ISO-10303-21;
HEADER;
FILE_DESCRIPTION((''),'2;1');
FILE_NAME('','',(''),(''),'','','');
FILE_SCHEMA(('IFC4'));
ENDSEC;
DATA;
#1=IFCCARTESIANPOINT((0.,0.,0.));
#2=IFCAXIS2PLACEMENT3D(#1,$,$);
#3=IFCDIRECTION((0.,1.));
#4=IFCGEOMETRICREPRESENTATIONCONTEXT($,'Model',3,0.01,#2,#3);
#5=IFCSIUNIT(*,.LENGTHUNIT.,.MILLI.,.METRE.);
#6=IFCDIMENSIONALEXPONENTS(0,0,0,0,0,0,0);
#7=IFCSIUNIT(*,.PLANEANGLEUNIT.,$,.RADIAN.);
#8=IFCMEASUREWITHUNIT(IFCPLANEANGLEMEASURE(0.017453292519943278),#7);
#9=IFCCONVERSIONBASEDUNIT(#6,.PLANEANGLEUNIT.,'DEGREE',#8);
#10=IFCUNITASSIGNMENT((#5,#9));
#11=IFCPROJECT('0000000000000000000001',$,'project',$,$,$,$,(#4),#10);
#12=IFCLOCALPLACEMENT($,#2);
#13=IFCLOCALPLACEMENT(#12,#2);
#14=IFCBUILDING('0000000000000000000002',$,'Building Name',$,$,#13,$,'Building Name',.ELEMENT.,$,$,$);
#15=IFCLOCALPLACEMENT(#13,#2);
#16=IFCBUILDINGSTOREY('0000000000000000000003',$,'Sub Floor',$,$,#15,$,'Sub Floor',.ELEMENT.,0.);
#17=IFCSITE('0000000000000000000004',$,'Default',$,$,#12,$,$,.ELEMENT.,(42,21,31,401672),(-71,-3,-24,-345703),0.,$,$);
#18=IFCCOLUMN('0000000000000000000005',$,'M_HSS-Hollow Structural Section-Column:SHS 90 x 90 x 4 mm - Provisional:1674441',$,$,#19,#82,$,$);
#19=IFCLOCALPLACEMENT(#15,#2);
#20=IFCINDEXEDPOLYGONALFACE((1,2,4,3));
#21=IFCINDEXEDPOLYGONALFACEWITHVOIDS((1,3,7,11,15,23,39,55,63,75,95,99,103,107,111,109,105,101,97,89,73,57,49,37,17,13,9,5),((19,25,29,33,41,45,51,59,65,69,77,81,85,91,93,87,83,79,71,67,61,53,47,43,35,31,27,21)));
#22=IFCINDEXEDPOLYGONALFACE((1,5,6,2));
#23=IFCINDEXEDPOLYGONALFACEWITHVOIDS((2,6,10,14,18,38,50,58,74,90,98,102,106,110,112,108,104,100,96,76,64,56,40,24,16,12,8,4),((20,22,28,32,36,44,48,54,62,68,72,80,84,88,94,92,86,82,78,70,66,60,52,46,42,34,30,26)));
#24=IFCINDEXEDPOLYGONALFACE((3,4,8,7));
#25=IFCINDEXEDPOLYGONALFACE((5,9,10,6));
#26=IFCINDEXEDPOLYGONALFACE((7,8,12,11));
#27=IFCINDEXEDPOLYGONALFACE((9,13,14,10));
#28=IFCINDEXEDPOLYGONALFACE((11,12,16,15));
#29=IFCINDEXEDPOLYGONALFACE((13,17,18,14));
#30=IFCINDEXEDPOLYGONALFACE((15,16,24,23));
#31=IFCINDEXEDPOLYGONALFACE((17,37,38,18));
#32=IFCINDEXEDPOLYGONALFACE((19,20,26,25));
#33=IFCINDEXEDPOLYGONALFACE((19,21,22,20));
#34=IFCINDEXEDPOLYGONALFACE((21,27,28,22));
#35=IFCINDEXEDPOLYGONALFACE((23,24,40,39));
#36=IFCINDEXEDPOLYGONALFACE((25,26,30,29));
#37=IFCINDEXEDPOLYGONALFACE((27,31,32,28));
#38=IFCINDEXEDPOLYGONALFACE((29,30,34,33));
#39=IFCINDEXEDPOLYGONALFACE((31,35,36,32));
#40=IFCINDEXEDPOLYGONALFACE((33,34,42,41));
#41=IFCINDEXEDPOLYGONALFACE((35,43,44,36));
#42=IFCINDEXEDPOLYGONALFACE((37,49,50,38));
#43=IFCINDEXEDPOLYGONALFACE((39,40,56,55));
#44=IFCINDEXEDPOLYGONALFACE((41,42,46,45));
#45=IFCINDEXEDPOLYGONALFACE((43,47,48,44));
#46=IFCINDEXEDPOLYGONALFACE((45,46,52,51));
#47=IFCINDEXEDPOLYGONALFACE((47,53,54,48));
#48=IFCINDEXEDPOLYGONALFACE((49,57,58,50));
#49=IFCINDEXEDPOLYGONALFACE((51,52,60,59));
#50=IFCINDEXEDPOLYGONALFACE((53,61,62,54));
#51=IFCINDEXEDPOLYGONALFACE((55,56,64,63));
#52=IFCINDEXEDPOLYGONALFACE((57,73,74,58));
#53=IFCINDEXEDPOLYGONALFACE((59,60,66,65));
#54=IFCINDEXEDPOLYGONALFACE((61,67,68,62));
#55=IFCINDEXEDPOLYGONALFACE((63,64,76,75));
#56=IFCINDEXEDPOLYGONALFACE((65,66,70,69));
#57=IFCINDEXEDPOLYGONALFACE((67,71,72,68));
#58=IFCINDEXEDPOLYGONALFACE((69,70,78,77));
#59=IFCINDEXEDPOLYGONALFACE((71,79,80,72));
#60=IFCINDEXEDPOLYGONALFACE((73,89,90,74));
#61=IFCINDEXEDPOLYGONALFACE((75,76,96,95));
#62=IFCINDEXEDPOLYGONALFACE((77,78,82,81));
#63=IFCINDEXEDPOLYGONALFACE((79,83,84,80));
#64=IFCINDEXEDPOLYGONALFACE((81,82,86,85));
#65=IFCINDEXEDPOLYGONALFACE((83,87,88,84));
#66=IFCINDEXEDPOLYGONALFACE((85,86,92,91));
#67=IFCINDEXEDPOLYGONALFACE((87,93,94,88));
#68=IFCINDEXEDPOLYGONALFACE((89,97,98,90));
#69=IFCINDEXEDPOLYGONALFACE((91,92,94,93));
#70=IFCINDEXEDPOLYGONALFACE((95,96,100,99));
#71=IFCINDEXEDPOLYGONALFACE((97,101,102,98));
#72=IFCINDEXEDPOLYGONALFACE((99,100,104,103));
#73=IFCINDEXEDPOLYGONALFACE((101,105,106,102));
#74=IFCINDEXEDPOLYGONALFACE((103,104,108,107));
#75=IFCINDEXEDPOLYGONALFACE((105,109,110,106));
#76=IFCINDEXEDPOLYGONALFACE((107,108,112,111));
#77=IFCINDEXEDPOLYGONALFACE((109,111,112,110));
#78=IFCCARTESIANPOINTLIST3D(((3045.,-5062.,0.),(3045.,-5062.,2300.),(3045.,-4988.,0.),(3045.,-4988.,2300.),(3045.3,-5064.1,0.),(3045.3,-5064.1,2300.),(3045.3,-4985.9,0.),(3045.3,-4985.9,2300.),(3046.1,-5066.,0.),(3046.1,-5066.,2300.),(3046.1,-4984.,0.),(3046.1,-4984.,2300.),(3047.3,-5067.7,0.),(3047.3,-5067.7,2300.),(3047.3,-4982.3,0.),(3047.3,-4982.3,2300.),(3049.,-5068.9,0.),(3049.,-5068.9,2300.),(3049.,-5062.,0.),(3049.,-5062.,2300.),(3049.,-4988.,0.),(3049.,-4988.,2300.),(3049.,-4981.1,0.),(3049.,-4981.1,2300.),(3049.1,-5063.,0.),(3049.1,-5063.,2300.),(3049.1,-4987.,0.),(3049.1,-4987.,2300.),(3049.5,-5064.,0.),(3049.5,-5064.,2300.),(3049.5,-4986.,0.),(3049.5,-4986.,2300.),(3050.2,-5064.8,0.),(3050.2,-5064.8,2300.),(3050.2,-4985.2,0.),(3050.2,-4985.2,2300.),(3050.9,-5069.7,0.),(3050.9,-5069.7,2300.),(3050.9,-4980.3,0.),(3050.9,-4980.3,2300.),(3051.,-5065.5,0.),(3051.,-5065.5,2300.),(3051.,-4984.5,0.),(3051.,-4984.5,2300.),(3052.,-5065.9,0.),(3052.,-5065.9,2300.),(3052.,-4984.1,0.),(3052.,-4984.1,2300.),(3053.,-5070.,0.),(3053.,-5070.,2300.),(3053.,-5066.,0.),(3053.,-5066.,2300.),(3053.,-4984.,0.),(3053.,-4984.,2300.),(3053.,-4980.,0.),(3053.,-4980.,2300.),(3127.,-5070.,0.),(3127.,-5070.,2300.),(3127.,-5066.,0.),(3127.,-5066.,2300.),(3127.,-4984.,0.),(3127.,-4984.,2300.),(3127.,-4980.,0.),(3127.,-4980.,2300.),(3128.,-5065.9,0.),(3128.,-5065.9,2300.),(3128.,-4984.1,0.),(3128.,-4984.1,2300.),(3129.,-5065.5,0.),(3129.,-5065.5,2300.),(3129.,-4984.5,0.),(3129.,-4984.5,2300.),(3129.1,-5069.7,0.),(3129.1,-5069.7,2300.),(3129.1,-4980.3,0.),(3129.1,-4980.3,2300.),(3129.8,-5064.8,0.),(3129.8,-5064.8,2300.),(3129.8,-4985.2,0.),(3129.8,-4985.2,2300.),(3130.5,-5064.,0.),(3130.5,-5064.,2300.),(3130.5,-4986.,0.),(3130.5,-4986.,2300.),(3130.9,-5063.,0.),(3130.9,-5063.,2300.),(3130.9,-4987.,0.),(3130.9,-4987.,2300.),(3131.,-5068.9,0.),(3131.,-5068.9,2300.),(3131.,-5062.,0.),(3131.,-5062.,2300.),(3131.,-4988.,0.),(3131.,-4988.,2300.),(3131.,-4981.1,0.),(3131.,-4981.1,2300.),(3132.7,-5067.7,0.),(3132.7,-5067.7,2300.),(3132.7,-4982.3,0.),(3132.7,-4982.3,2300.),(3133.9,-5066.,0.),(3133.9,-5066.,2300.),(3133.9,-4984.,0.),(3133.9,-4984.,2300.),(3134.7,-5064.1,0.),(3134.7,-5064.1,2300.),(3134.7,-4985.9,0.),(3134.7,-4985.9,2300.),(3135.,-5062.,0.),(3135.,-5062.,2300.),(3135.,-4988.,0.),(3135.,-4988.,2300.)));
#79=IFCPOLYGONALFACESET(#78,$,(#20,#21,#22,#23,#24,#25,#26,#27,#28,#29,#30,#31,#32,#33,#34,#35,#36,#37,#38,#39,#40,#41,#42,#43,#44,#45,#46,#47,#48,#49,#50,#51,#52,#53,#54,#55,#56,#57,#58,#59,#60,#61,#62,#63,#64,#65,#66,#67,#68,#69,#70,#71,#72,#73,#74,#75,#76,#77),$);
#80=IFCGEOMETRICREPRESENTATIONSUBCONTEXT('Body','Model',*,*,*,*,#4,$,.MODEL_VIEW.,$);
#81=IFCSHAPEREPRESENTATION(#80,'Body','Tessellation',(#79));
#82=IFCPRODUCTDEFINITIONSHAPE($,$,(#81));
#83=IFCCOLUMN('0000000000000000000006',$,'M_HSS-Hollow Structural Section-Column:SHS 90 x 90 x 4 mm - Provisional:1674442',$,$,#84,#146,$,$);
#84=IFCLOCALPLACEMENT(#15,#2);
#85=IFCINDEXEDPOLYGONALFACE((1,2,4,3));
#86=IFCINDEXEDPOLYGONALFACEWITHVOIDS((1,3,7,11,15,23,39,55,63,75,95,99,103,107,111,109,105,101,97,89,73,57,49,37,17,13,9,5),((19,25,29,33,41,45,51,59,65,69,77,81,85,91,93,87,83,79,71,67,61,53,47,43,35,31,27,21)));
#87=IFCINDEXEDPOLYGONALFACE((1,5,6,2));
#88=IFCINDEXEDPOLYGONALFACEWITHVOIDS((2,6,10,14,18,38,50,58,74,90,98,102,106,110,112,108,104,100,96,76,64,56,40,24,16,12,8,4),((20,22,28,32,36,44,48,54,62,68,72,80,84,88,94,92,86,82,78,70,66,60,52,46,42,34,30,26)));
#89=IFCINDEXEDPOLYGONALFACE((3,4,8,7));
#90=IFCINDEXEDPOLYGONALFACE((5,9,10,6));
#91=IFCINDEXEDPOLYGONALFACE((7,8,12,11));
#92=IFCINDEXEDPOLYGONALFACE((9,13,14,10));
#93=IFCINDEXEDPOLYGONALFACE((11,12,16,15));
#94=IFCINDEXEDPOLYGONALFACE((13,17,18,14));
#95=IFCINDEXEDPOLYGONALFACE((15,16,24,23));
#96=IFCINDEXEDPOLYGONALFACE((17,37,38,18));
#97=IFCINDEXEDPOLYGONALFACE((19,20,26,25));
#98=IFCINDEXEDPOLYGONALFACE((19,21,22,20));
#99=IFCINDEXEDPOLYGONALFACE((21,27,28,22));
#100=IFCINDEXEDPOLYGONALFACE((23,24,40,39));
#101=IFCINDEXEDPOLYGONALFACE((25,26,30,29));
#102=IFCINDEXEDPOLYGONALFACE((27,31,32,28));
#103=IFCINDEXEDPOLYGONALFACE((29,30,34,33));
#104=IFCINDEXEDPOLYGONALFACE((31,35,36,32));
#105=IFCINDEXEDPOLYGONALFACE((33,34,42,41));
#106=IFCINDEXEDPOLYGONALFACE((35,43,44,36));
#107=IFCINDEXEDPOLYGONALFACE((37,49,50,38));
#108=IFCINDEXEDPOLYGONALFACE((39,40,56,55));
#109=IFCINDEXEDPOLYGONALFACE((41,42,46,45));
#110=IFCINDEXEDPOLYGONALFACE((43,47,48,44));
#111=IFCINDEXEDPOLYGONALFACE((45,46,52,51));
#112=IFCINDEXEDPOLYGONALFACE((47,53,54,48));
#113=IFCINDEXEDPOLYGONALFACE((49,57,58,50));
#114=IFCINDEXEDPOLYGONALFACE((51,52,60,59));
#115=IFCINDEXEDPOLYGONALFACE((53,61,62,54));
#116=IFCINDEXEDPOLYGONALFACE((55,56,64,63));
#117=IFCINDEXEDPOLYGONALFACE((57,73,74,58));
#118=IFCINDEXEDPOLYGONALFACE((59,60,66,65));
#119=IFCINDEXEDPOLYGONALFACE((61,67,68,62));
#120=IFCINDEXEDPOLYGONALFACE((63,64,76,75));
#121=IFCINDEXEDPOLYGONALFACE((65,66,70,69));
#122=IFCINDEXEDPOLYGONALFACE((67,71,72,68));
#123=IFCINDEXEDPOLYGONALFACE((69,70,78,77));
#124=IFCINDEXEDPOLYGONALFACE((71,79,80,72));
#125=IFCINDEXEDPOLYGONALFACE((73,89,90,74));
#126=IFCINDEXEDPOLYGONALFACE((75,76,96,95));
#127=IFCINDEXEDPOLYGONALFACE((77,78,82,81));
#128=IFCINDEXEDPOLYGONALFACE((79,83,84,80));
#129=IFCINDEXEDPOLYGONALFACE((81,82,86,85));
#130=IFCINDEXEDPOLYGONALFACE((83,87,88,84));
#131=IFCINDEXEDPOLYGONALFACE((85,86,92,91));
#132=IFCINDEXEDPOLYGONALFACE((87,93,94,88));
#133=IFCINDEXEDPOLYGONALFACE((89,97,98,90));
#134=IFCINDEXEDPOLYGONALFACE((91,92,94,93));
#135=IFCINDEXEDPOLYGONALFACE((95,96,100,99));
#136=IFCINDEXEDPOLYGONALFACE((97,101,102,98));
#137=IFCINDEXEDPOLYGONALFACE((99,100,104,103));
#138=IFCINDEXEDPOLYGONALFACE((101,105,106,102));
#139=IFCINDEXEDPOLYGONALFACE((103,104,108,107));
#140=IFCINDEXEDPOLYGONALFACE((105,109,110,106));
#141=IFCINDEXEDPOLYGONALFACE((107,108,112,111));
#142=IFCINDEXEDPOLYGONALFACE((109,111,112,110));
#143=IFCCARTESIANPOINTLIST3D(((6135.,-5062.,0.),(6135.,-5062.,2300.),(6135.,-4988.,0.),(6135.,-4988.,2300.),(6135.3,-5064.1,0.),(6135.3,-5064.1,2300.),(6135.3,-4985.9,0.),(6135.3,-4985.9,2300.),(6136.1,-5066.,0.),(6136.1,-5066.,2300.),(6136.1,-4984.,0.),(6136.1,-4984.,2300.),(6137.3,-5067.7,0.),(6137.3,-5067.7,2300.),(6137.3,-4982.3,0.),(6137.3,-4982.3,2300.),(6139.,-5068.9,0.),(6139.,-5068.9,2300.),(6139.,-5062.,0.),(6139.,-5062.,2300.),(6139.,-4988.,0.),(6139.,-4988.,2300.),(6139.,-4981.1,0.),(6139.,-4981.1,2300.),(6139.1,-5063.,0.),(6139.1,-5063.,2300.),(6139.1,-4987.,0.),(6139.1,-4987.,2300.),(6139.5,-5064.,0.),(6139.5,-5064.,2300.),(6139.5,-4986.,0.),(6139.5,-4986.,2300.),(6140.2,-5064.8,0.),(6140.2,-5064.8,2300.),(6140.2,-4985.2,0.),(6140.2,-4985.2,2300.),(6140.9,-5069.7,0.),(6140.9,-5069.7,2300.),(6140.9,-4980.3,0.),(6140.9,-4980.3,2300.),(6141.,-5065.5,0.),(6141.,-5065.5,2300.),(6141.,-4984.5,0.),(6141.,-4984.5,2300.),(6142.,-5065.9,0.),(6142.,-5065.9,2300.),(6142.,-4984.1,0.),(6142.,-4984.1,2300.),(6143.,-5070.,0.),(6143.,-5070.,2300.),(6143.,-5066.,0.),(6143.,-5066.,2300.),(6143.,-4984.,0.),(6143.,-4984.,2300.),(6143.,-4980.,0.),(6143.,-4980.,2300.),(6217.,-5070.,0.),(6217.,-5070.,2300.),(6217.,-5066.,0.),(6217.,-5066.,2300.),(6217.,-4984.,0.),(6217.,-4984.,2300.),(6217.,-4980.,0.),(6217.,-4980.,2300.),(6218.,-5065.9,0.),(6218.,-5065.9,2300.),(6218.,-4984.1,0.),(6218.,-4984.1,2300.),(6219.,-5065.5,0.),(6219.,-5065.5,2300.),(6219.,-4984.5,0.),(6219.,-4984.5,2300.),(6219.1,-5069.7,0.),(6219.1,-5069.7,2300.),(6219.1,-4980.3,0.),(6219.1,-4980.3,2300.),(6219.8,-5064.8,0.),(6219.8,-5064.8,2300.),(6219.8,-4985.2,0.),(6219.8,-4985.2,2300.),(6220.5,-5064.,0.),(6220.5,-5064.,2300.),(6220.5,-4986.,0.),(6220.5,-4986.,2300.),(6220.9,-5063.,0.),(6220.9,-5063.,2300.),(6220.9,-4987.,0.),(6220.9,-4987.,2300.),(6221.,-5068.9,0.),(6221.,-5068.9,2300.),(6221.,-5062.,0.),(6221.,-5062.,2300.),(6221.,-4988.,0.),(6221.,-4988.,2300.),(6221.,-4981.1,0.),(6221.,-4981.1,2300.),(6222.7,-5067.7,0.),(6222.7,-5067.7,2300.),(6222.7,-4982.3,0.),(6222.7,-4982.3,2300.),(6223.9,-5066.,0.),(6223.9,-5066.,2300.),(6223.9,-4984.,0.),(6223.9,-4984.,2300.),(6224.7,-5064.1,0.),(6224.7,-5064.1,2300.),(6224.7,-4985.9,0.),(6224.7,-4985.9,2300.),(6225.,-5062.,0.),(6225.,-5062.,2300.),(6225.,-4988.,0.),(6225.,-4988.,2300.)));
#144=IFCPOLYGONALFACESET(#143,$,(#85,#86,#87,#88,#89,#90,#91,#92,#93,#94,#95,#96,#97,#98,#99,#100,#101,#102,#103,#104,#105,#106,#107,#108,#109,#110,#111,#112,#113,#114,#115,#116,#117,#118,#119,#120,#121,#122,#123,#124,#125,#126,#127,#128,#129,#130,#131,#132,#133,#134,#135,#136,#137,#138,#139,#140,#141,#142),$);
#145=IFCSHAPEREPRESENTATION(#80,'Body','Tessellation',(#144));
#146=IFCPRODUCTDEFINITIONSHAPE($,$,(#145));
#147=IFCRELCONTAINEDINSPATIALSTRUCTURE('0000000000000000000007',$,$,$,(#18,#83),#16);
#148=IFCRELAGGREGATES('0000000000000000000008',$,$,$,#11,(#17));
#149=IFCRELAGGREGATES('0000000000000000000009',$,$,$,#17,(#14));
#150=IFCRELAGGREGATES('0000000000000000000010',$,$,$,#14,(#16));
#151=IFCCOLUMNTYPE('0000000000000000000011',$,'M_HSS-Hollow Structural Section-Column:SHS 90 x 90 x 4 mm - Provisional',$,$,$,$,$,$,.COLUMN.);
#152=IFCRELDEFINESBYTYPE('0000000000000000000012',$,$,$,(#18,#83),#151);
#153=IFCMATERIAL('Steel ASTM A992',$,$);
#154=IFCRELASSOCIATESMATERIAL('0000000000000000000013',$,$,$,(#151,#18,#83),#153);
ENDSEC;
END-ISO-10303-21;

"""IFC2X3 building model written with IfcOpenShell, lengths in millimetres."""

from ifc_helpers import new_model, entity, si_unit, converted_unit, direction, frame, frame_2d, origin, place, context, subcontext, project, spatial, polyline, circle_curve, parameter, trimmed, segment, composite_curve, outline, extrude, source, transform, mapped, material, type_object, type_shapes, element, save


model = new_model("IFC2X3")

# Units and contexts
model_context = context("Model", 3, precision=0.01, world=origin(), true_north=direction((0.0, 1.0)))
body_context = subcontext(model_context, "Body", "Model", "MODEL_VIEW")
ifc_project = project(units=[si_unit("LENGTHUNIT", "METRE", prefix="MILLI"), converted_unit("PLANEANGLEUNIT", "DEGREE", entity("IfcPlaneAngleMeasure", 0.017453292519943278), si_unit("PLANEANGLEUNIT", "RADIAN"), dimensions=[0, 0, 0, 0, 0, 0, 0])], contexts=[model_context])

# Site, building, storey
site_placement = place(None, origin())
site = spatial("IfcSite", under=ifc_project, at=site_placement, Name="Default", CompositionType="ELEMENT", RefLatitude=(42, 21, 31, 401672), RefLongitude=(-71, -3, -24, -345703), RefElevation=0.0)
building_placement = place(site_placement, origin())
building = spatial("IfcBuilding", under=site, at=building_placement, Name="Building Name", LongName="Building Name", CompositionType="ELEMENT")
storey_placement = place(building_placement, origin())
storey = spatial("IfcBuildingStorey", under=building, at=storey_placement, Name="Sub Floor", LongName="Sub Floor", CompositionType="ELEMENT", Elevation=0.0)

# Columns
ifc_material_1 = material(Name="Steel ASTM A992")
column_type = type_object("IfcColumnType", Name="M_HSS-Hollow Structural Section-Column:SHS 90 x 90 x 4 mm - Provisional", PredefinedType="COLUMN", material=ifc_material_1)
shared_shape_1 = source(origin(), body_context, "Body", "SweptSolid", [
    extrude(outline(composite_curve([segment(polyline([(-37.0, -45.0), (37.0, -45.0)]), True, "CONTINUOUS"), segment(trimmed(circle_curve(frame_2d((37.0, -37.0), x_axis=(-1.0, 0.0)), 8.0), [parameter(90.0)], [parameter(180.0)], True, "PARAMETER"), True, "CONTINUOUS"), segment(polyline([(45.0, -37.0), (45.0, 37.0)]), True, "CONTINUOUS"), segment(trimmed(circle_curve(frame_2d((37.0, 37.0), x_axis=(-1.0, 0.0)), 8.0), [parameter(180.0)], [parameter(270.0)], True, "PARAMETER"), True, "CONTINUOUS"), segment(polyline([(37.0, 45.0), (-37.0, 45.0)]), True, "CONTINUOUS"), segment(trimmed(circle_curve(frame_2d((-37.0, 37.0), x_axis=(-1.0, 0.0)), 8.0), [parameter(270.0)], [parameter(360.0)], True, "PARAMETER"), True, "CONTINUOUS"), segment(polyline([(-45.0, 37.0), (-45.0, -37.0)]), True, "CONTINUOUS"), segment(trimmed(circle_curve(frame_2d((-37.0, -37.0), x_axis=(-1.0, 0.0)), 8.0), [parameter(360.0)], [parameter(90.0)], True, "PARAMETER"), True, "CONTINUOUS")], self_intersect=False), holes=[composite_curve([segment(trimmed(circle_curve(frame_2d((-37.0, -37.0), x_axis=(-1.0, 0.0)), 4.0), [parameter(0.0)], [parameter(90.0)], True, "PARAMETER"), False, "CONTINUOUS"), segment(polyline([(-41.0, -37.0), (-41.0, 37.0)]), True, "CONTINUOUS"), segment(trimmed(circle_curve(frame_2d((-37.0, 37.0), x_axis=(-1.0, 0.0)), 4.0), [parameter(270.0)], [parameter(0.0)], True, "PARAMETER"), False, "CONTINUOUS"), segment(polyline([(-37.0, 41.0), (37.0, 41.0)]), True, "CONTINUOUS"), segment(trimmed(circle_curve(frame_2d((37.0, 37.0), x_axis=(-1.0, 0.0)), 4.0), [parameter(180.0)], [parameter(270.0)], True, "PARAMETER"), False, "CONTINUOUS"), segment(polyline([(41.0, 37.0), (41.0, -37.0)]), True, "CONTINUOUS"), segment(trimmed(circle_curve(frame_2d((37.0, -37.0), x_axis=(-1.0, 0.0)), 4.0), [parameter(90.0)], [parameter(180.0)], True, "PARAMETER"), False, "CONTINUOUS"), segment(polyline([(37.0, -41.0), (-37.0, -41.0)]), True, "CONTINUOUS")], self_intersect=False)]), frame((0.0, 0.0, 0.0), z_axis=(0.0, 0.0, 1.0), x_axis=(-1.0, 0.0, 0.0)), (0.0, 0.0, 1.0), 2300.0),
])
type_shapes(column_type, [shared_shape_1])
for number, where, name in (
    (1, (3090.0, -5025.0, 0.0), "M_HSS-Hollow Structural Section-Column:SHS 90 x 90 x 4 mm - Provisional:1674441"),
    (2, (6180.0, -5025.0, 0.0), "M_HSS-Hollow Structural Section-Column:SHS 90 x 90 x 4 mm - Provisional:1674442"),
):
    element("IfcColumn", number, at=place(storey_placement, frame(where)), inside=storey, type_object=column_type, material=ifc_material_1, Name=name, context=body_context, shape_type="MappedRepresentation", body=[
        mapped(shared_shape_1, transform((0.0, 0.0, 0.0), scale=1.0)),
    ])

save(model, "model.ifc")
